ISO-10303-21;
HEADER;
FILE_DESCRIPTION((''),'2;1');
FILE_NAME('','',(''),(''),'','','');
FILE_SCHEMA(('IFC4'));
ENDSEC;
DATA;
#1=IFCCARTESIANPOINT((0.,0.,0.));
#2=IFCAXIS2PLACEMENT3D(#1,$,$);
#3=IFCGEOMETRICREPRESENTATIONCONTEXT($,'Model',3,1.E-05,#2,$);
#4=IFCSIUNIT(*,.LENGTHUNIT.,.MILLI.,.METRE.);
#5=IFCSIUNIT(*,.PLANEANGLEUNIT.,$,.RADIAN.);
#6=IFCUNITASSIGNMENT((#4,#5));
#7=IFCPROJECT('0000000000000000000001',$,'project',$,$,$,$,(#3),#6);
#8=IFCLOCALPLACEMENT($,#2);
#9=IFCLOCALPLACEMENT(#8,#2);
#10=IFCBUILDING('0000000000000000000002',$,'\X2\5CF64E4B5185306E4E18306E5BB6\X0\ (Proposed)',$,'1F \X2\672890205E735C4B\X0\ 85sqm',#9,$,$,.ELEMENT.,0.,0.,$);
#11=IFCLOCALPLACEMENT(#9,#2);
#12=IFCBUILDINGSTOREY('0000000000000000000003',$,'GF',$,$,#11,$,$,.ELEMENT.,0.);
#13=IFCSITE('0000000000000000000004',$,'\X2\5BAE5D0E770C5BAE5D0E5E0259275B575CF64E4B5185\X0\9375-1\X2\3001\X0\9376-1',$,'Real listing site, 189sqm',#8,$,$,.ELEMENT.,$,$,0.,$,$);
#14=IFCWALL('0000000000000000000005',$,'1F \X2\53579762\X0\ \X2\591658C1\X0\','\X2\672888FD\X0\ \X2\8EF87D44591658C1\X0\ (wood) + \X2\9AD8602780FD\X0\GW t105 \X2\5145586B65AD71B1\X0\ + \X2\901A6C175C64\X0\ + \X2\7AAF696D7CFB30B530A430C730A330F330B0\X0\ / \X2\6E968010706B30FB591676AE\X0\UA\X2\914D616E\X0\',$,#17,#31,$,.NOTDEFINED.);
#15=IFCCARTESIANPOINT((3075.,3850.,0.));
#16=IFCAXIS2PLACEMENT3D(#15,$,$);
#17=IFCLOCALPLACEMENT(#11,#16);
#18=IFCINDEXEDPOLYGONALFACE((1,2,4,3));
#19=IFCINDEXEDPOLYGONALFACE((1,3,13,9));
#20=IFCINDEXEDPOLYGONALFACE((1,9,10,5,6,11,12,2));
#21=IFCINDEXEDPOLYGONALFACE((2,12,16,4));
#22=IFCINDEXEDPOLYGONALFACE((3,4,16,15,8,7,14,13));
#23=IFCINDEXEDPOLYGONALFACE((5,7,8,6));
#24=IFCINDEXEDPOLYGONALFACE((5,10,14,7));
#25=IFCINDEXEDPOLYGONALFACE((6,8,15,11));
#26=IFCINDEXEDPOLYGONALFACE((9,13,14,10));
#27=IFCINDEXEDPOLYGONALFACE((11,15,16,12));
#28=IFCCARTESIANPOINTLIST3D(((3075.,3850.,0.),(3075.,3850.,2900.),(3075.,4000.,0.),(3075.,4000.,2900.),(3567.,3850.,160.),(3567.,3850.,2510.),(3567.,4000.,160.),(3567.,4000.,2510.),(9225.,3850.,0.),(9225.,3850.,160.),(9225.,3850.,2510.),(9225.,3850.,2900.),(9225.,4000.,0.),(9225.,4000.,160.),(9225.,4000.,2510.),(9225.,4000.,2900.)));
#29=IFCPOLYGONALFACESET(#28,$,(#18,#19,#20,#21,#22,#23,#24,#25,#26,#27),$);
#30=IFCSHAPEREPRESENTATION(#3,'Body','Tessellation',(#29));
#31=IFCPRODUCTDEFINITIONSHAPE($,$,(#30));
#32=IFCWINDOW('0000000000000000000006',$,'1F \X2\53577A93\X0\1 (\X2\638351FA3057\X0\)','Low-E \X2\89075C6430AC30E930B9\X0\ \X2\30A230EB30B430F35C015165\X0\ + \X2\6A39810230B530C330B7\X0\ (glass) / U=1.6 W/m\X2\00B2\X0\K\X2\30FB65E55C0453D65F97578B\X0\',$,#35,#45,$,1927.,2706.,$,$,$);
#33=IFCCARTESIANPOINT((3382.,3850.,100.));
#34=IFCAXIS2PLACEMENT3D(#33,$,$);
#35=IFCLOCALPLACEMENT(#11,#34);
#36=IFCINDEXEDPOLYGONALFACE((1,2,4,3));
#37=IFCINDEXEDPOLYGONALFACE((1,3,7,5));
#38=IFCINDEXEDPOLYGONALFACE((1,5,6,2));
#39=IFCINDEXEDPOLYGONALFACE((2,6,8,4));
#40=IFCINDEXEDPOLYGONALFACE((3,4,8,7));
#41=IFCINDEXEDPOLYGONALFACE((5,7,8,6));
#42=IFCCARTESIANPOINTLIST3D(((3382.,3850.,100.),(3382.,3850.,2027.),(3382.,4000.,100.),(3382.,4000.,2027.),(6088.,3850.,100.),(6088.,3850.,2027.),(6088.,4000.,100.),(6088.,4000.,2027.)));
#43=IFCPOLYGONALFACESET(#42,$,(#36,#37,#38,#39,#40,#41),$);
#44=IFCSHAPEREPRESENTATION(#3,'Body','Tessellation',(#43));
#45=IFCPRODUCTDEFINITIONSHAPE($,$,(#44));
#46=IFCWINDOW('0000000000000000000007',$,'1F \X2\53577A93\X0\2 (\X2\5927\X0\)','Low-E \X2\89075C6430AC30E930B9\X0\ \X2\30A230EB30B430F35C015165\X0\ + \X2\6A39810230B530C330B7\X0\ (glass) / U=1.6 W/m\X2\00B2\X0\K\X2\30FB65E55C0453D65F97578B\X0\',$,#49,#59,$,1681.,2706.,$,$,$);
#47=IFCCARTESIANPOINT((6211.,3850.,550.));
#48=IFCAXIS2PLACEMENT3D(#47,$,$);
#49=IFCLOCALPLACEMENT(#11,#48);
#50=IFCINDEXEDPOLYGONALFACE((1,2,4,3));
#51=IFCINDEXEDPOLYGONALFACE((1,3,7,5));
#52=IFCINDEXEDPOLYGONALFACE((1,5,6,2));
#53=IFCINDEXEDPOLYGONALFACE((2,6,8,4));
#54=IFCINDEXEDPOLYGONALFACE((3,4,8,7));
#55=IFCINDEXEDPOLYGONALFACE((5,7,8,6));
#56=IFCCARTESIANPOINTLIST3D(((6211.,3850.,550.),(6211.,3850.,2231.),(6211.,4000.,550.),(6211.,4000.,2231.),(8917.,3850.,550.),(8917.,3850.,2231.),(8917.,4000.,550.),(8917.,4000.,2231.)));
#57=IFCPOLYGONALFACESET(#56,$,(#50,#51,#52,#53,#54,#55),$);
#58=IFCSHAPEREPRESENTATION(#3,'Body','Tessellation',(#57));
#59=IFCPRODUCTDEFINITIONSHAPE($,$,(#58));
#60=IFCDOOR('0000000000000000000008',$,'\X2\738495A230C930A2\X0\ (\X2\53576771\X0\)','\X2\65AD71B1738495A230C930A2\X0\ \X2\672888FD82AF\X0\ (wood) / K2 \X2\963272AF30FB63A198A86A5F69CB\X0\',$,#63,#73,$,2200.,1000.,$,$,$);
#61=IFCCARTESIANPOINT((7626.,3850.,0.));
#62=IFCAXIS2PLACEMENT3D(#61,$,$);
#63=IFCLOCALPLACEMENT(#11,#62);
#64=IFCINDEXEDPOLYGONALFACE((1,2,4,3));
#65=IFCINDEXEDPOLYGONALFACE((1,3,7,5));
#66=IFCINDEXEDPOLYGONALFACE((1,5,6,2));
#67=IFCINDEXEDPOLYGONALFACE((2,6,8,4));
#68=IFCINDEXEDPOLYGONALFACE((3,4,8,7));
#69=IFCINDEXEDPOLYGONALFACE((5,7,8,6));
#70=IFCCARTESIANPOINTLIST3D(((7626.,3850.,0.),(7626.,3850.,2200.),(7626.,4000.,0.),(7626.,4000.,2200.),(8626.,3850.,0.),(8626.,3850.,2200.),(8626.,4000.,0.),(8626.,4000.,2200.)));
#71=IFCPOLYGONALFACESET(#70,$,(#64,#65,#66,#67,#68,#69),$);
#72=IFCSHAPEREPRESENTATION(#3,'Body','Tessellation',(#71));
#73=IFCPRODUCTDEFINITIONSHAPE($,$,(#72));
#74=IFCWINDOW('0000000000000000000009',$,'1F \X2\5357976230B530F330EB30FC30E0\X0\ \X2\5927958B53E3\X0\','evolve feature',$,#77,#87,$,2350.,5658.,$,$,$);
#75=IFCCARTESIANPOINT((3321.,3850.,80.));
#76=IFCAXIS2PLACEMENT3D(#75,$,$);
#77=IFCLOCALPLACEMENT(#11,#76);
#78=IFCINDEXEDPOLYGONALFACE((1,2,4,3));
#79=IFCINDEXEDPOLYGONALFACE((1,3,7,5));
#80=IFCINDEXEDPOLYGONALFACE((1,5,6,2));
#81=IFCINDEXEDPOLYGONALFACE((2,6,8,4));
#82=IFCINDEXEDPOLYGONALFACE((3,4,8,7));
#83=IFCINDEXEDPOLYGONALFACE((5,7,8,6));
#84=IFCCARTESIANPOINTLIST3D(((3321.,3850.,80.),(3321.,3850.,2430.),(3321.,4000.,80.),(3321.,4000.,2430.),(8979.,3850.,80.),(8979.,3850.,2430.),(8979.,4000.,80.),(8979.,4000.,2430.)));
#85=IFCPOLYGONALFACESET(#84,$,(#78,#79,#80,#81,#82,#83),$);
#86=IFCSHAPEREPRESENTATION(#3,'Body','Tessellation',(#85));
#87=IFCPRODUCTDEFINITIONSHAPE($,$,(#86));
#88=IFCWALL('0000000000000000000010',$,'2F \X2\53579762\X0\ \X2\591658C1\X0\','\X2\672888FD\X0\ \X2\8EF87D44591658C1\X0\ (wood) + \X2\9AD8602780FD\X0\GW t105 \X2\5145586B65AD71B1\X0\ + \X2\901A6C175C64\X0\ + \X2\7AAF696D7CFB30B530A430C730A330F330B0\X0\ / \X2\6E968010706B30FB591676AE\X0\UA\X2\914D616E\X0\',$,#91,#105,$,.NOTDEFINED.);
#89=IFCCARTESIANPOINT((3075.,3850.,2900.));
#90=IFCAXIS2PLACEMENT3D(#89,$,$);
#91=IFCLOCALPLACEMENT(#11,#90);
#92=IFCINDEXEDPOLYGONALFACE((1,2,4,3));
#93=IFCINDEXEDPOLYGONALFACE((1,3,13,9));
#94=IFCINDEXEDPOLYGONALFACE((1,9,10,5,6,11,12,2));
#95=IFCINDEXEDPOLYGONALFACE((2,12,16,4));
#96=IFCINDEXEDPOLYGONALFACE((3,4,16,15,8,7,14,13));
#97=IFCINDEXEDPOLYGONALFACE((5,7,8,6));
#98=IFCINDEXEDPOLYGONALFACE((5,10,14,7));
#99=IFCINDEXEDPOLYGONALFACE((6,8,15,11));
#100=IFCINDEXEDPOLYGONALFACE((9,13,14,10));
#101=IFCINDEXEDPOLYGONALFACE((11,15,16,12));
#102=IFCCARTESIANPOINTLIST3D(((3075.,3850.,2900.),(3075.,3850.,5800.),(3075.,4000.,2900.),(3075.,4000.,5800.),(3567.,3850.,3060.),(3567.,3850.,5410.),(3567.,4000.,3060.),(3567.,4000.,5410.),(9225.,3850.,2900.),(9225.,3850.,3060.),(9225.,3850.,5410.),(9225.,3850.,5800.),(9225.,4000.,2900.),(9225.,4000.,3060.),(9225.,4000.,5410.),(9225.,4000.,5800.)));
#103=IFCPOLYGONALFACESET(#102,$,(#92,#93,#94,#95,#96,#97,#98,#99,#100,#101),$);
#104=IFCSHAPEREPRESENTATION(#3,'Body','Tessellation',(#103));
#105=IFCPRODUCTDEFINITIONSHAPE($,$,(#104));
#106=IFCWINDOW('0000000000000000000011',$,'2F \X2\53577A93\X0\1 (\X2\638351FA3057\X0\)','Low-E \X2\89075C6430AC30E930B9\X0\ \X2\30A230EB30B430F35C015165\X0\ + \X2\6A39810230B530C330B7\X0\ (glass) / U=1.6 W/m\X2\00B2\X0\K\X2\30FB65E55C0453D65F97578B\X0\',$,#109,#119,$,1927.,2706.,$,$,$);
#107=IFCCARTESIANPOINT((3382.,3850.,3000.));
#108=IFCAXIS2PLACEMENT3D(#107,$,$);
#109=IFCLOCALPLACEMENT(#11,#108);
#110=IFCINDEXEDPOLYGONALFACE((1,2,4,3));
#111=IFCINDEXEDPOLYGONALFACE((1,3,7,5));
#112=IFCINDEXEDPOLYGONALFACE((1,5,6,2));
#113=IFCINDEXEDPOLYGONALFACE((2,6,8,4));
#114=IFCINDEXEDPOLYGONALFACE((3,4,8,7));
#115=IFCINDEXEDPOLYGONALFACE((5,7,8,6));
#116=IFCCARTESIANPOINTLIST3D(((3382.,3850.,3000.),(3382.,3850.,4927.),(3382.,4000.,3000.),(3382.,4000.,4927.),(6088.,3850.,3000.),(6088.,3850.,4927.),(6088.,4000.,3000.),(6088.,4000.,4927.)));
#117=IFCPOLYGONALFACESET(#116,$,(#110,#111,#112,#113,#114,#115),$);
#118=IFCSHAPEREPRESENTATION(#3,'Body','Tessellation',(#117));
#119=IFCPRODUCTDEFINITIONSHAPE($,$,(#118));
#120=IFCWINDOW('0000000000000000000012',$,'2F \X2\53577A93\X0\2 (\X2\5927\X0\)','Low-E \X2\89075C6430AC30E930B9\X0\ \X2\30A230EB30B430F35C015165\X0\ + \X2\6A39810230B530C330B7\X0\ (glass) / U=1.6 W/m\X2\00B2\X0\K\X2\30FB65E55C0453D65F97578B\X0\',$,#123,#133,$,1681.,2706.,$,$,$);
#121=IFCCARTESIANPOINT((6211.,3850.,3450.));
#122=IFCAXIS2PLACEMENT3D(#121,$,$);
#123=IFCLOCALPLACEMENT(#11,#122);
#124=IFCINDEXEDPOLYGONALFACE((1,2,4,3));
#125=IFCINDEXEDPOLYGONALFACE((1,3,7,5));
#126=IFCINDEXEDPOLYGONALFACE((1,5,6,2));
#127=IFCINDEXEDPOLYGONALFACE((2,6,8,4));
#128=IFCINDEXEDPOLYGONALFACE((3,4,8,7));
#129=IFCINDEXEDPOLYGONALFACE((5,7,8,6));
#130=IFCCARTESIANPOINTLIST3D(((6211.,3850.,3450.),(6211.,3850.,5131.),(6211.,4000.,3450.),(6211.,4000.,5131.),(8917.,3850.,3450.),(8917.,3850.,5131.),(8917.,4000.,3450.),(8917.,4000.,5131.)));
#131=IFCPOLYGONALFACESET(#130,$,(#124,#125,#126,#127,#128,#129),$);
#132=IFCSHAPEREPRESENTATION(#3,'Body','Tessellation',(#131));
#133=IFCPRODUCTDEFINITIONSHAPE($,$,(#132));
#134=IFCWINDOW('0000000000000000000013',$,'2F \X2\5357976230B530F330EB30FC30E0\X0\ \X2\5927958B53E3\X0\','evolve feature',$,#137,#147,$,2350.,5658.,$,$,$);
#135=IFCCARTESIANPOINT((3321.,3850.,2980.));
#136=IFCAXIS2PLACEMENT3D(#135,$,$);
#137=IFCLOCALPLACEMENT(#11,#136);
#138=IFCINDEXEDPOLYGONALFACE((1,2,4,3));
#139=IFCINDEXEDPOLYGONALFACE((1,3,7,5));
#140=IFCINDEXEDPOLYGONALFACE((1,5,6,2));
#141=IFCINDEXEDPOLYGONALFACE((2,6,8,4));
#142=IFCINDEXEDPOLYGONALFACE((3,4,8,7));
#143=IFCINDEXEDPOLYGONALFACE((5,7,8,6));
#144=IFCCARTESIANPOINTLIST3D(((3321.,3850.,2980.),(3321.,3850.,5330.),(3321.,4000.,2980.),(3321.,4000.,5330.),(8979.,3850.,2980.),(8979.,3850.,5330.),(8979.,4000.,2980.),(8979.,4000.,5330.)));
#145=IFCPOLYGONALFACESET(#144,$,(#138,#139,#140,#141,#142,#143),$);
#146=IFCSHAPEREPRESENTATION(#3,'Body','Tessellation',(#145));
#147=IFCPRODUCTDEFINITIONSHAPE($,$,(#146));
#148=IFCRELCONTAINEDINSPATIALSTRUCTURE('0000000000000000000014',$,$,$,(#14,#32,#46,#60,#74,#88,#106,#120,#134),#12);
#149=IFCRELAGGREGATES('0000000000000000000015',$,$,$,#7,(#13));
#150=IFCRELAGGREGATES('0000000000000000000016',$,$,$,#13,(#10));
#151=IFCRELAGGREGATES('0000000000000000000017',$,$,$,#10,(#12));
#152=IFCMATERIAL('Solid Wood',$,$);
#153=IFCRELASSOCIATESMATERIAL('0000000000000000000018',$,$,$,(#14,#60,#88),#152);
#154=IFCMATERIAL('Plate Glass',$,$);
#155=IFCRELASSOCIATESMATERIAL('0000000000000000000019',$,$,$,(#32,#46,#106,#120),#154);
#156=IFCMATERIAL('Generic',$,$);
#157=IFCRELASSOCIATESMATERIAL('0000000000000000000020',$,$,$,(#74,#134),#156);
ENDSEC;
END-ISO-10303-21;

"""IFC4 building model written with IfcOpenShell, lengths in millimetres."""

from ifc_helpers import new_model, si_unit, frame, frame_2d, origin, place, context, project, spatial, rectangle, extrude, material, element, fill, save


model = new_model("IFC4")

# Units and contexts
model_context = context("Model", 3, precision=1e-05, world=origin())
ifc_project = project(units=[si_unit("LENGTHUNIT", "METRE", prefix="MILLI"), si_unit("PLANEANGLEUNIT", "RADIAN")], contexts=[model_context])

# Site, building, storey
site_placement = place(None, origin())
site = spatial("IfcSite", under=ifc_project, at=site_placement, Name="宮崎県宮崎市大字島之内9375-1、9376-1", ObjectType="Real listing site, 189sqm", CompositionType="ELEMENT", RefElevation=0.0)
building_placement = place(site_placement, origin())
building = spatial("IfcBuilding", under=site, at=building_placement, Name="島之内の丘の家 (Proposed)", ObjectType="1F 木造平屋 85sqm", CompositionType="ELEMENT", ElevationOfRefHeight=0.0, ElevationOfTerrain=0.0)
storey_placement = place(building_placement, origin())
storey = spatial("IfcBuildingStorey", under=building, at=storey_placement, Name="GF", CompositionType="ELEMENT", Elevation=0.0)

# Shared definitions
ifc_material_1 = material(Name="Solid Wood")
ifc_material_2 = material(Name="Generic")

# Wall, openings, windows, door
wall_1_placement = place(storey_placement, frame((3075.0, 3850.0, 0.0)))
wall_1 = element("IfcWall", 1, at=wall_1_placement, inside=storey, material=ifc_material_1, Name="1F 南面 外壁", Description="木製 軸組外壁 (wood) + 高性能GW t105 充填断熱 + 通気層 + 窯業系サイディング / 準耐火・外皮UA配慮", PredefinedType="NOTDEFINED", context=model_context, shape_type="SweptSolid", body=[
    extrude(rectangle(XDim=6150.0, YDim=150.0, at=frame_2d((3075.0, 75.0))), frame((3075.0, 3850.0, 0.0)), (0.0, 0.0, 1.0), 2900.0),
])
opening_1_placement = place(storey_placement, frame((3382.0, 3850.0, 100.0)))
opening_1 = element("IfcOpeningElement", 2, at=opening_1_placement, cuts=wall_1, PredefinedType="NOTDEFINED", context=model_context, shape_type="SweptSolid", body=[
    extrude(rectangle(XDim=2706.0, YDim=150.0, at=frame_2d((1353.0, 75.0))), frame((3382.0, 3850.0, 100.0)), (0.0, 0.0, 1.0), 1927.0),
])
opening_2_placement = place(storey_placement, frame((6211.0, 3850.0, 550.0)))
opening_2 = element("IfcOpeningElement", 3, at=opening_2_placement, cuts=wall_1, PredefinedType="NOTDEFINED", context=model_context, shape_type="SweptSolid", body=[
    extrude(rectangle(XDim=2706.0, YDim=150.0, at=frame_2d((1353.0, 75.0))), frame((6211.0, 3850.0, 550.0)), (0.0, 0.0, 1.0), 1681.0),
])
opening_3_placement = place(storey_placement, frame((7626.0, 3850.0, 0.0)))
opening_3 = element("IfcOpeningElement", 4, at=opening_3_placement, cuts=wall_1, PredefinedType="NOTDEFINED", context=model_context, shape_type="SweptSolid", body=[
    extrude(rectangle(XDim=1000.0, YDim=150.0, at=frame_2d((500.0, 75.0))), frame((7626.0, 3850.0, 0.0)), (0.0, 0.0, 1.0), 2200.0),
])
opening_4_placement = place(storey_placement, frame((3321.0, 3850.0, 80.0)))
opening_4 = element("IfcOpeningElement", 5, at=opening_4_placement, cuts=wall_1, PredefinedType="NOTDEFINED", context=model_context, shape_type="SweptSolid", body=[
    extrude(rectangle(XDim=5658.0, YDim=150.0, at=frame_2d((2829.0, 75.0))), frame((3321.0, 3850.0, 80.0)), (0.0, 0.0, 1.0), 2350.0),
])
ifc_material_3 = material(Name="Plate Glass")
window_1_placement = place(storey_placement, frame((3382.0, 3850.0, 100.0)))
window_1 = element("IfcWindow", 6, at=window_1_placement, inside=storey, material=ifc_material_3, Name="1F 南窓1 (掃出し)", Description="Low-E 複層ガラス アルゴン封入 + 樹脂サッシ (glass) / U=1.6 W/m²K・日射取得型", OverallHeight=1927.0, OverallWidth=2706.0, context=model_context, shape_type="SweptSolid", body=[
    extrude(rectangle(XDim=2706.0, YDim=150.0, at=frame_2d((1353.0, 75.0))), frame((3382.0, 3850.0, 100.0)), (0.0, 0.0, 1.0), 1927.0),
])
fill(opening_1, window_1)
window_2_placement = place(storey_placement, frame((6211.0, 3850.0, 550.0)))
window_2 = element("IfcWindow", 7, at=window_2_placement, inside=storey, material=ifc_material_3, Name="1F 南窓2 (大)", Description="Low-E 複層ガラス アルゴン封入 + 樹脂サッシ (glass) / U=1.6 W/m²K・日射取得型", OverallHeight=1681.0, OverallWidth=2706.0, context=model_context, shape_type="SweptSolid", body=[
    extrude(rectangle(XDim=2706.0, YDim=150.0, at=frame_2d((1353.0, 75.0))), frame((6211.0, 3850.0, 550.0)), (0.0, 0.0, 1.0), 1681.0),
])
fill(opening_2, window_2)
door_placement = place(storey_placement, frame((7626.0, 3850.0, 0.0)))
door = element("IfcDoor", 8, at=door_placement, inside=storey, material=ifc_material_1, Name="玄関ドア (南東)", Description="断熱玄関ドア 木製芯 (wood) / K2 防犯・採風機構", OverallHeight=2200.0, OverallWidth=1000.0, context=model_context, shape_type="SweptSolid", body=[
    extrude(rectangle(XDim=1000.0, YDim=150.0, at=frame_2d((500.0, 75.0))), frame((7626.0, 3850.0, 0.0)), (0.0, 0.0, 1.0), 2200.0),
])
fill(opening_3, door)
window_3_placement = place(storey_placement, frame((3321.0, 3850.0, 80.0)))
window_3 = element("IfcWindow", 9, at=window_3_placement, inside=storey, material=ifc_material_2, Name="1F 南面サンルーム 大開口", Description="evolve feature", OverallHeight=2350.0, OverallWidth=5658.0, context=model_context, shape_type="SweptSolid", body=[
    extrude(rectangle(XDim=5658.0, YDim=150.0, at=frame_2d((2829.0, 75.0))), frame((3321.0, 3850.0, 80.0)), (0.0, 0.0, 1.0), 2350.0),
])
fill(opening_4, window_3)

# Wall, openings, windows
wall_2_placement = place(storey_placement, frame((3075.0, 3850.0, 2900.0)))
wall_2 = element("IfcWall", 10, at=wall_2_placement, inside=storey, material=ifc_material_1, Name="2F 南面 外壁", Description="木製 軸組外壁 (wood) + 高性能GW t105 充填断熱 + 通気層 + 窯業系サイディング / 準耐火・外皮UA配慮", PredefinedType="NOTDEFINED", context=model_context, shape_type="SweptSolid", body=[
    extrude(rectangle(XDim=6150.0, YDim=150.0, at=frame_2d((3075.0, 75.0))), frame((3075.0, 3850.0, 2900.0)), (0.0, 0.0, 1.0), 2900.0),
])
opening_5_placement = place(storey_placement, frame((3382.0, 3850.0, 3000.0)))
opening_5 = element("IfcOpeningElement", 11, at=opening_5_placement, cuts=wall_2, PredefinedType="NOTDEFINED", context=model_context, shape_type="SweptSolid", body=[
    extrude(rectangle(XDim=2706.0, YDim=150.0, at=frame_2d((1353.0, 75.0))), frame((3382.0, 3850.0, 3000.0)), (0.0, 0.0, 1.0), 1927.0),
])
opening_6_placement = place(storey_placement, frame((6211.0, 3850.0, 3450.0)))
opening_6 = element("IfcOpeningElement", 12, at=opening_6_placement, cuts=wall_2, PredefinedType="NOTDEFINED", context=model_context, shape_type="SweptSolid", body=[
    extrude(rectangle(XDim=2706.0, YDim=150.0, at=frame_2d((1353.0, 75.0))), frame((6211.0, 3850.0, 3450.0)), (0.0, 0.0, 1.0), 1681.0),
])
opening_7_placement = place(storey_placement, frame((3321.0, 3850.0, 2980.0)))
opening_7 = element("IfcOpeningElement", 13, at=opening_7_placement, cuts=wall_2, PredefinedType="NOTDEFINED", context=model_context, shape_type="SweptSolid", body=[
    extrude(rectangle(XDim=5658.0, YDim=150.0, at=frame_2d((2829.0, 75.0))), frame((3321.0, 3850.0, 2980.0)), (0.0, 0.0, 1.0), 2350.0),
])
window_4_placement = place(storey_placement, frame((3382.0, 3850.0, 3000.0)))
window_4 = element("IfcWindow", 14, at=window_4_placement, inside=storey, material=ifc_material_3, Name="2F 南窓1 (掃出し)", Description="Low-E 複層ガラス アルゴン封入 + 樹脂サッシ (glass) / U=1.6 W/m²K・日射取得型", OverallHeight=1927.0, OverallWidth=2706.0, context=model_context, shape_type="SweptSolid", body=[
    extrude(rectangle(XDim=2706.0, YDim=150.0, at=frame_2d((1353.0, 75.0))), frame((3382.0, 3850.0, 3000.0)), (0.0, 0.0, 1.0), 1927.0),
])
fill(opening_5, window_4)
window_5_placement = place(storey_placement, frame((6211.0, 3850.0, 3450.0)))
window_5 = element("IfcWindow", 15, at=window_5_placement, inside=storey, material=ifc_material_3, Name="2F 南窓2 (大)", Description="Low-E 複層ガラス アルゴン封入 + 樹脂サッシ (glass) / U=1.6 W/m²K・日射取得型", OverallHeight=1681.0, OverallWidth=2706.0, context=model_context, shape_type="SweptSolid", body=[
    extrude(rectangle(XDim=2706.0, YDim=150.0, at=frame_2d((1353.0, 75.0))), frame((6211.0, 3850.0, 3450.0)), (0.0, 0.0, 1.0), 1681.0),
])
fill(opening_6, window_5)
window_6_placement = place(storey_placement, frame((3321.0, 3850.0, 2980.0)))
window_6 = element("IfcWindow", 16, at=window_6_placement, inside=storey, material=ifc_material_2, Name="2F 南面サンルーム 大開口", Description="evolve feature", OverallHeight=2350.0, OverallWidth=5658.0, context=model_context, shape_type="SweptSolid", body=[
    extrude(rectangle(XDim=5658.0, YDim=150.0, at=frame_2d((2829.0, 75.0))), frame((3321.0, 3850.0, 2980.0)), (0.0, 0.0, 1.0), 2350.0),
])
fill(opening_7, window_6)

save(model, "model.ifc")
